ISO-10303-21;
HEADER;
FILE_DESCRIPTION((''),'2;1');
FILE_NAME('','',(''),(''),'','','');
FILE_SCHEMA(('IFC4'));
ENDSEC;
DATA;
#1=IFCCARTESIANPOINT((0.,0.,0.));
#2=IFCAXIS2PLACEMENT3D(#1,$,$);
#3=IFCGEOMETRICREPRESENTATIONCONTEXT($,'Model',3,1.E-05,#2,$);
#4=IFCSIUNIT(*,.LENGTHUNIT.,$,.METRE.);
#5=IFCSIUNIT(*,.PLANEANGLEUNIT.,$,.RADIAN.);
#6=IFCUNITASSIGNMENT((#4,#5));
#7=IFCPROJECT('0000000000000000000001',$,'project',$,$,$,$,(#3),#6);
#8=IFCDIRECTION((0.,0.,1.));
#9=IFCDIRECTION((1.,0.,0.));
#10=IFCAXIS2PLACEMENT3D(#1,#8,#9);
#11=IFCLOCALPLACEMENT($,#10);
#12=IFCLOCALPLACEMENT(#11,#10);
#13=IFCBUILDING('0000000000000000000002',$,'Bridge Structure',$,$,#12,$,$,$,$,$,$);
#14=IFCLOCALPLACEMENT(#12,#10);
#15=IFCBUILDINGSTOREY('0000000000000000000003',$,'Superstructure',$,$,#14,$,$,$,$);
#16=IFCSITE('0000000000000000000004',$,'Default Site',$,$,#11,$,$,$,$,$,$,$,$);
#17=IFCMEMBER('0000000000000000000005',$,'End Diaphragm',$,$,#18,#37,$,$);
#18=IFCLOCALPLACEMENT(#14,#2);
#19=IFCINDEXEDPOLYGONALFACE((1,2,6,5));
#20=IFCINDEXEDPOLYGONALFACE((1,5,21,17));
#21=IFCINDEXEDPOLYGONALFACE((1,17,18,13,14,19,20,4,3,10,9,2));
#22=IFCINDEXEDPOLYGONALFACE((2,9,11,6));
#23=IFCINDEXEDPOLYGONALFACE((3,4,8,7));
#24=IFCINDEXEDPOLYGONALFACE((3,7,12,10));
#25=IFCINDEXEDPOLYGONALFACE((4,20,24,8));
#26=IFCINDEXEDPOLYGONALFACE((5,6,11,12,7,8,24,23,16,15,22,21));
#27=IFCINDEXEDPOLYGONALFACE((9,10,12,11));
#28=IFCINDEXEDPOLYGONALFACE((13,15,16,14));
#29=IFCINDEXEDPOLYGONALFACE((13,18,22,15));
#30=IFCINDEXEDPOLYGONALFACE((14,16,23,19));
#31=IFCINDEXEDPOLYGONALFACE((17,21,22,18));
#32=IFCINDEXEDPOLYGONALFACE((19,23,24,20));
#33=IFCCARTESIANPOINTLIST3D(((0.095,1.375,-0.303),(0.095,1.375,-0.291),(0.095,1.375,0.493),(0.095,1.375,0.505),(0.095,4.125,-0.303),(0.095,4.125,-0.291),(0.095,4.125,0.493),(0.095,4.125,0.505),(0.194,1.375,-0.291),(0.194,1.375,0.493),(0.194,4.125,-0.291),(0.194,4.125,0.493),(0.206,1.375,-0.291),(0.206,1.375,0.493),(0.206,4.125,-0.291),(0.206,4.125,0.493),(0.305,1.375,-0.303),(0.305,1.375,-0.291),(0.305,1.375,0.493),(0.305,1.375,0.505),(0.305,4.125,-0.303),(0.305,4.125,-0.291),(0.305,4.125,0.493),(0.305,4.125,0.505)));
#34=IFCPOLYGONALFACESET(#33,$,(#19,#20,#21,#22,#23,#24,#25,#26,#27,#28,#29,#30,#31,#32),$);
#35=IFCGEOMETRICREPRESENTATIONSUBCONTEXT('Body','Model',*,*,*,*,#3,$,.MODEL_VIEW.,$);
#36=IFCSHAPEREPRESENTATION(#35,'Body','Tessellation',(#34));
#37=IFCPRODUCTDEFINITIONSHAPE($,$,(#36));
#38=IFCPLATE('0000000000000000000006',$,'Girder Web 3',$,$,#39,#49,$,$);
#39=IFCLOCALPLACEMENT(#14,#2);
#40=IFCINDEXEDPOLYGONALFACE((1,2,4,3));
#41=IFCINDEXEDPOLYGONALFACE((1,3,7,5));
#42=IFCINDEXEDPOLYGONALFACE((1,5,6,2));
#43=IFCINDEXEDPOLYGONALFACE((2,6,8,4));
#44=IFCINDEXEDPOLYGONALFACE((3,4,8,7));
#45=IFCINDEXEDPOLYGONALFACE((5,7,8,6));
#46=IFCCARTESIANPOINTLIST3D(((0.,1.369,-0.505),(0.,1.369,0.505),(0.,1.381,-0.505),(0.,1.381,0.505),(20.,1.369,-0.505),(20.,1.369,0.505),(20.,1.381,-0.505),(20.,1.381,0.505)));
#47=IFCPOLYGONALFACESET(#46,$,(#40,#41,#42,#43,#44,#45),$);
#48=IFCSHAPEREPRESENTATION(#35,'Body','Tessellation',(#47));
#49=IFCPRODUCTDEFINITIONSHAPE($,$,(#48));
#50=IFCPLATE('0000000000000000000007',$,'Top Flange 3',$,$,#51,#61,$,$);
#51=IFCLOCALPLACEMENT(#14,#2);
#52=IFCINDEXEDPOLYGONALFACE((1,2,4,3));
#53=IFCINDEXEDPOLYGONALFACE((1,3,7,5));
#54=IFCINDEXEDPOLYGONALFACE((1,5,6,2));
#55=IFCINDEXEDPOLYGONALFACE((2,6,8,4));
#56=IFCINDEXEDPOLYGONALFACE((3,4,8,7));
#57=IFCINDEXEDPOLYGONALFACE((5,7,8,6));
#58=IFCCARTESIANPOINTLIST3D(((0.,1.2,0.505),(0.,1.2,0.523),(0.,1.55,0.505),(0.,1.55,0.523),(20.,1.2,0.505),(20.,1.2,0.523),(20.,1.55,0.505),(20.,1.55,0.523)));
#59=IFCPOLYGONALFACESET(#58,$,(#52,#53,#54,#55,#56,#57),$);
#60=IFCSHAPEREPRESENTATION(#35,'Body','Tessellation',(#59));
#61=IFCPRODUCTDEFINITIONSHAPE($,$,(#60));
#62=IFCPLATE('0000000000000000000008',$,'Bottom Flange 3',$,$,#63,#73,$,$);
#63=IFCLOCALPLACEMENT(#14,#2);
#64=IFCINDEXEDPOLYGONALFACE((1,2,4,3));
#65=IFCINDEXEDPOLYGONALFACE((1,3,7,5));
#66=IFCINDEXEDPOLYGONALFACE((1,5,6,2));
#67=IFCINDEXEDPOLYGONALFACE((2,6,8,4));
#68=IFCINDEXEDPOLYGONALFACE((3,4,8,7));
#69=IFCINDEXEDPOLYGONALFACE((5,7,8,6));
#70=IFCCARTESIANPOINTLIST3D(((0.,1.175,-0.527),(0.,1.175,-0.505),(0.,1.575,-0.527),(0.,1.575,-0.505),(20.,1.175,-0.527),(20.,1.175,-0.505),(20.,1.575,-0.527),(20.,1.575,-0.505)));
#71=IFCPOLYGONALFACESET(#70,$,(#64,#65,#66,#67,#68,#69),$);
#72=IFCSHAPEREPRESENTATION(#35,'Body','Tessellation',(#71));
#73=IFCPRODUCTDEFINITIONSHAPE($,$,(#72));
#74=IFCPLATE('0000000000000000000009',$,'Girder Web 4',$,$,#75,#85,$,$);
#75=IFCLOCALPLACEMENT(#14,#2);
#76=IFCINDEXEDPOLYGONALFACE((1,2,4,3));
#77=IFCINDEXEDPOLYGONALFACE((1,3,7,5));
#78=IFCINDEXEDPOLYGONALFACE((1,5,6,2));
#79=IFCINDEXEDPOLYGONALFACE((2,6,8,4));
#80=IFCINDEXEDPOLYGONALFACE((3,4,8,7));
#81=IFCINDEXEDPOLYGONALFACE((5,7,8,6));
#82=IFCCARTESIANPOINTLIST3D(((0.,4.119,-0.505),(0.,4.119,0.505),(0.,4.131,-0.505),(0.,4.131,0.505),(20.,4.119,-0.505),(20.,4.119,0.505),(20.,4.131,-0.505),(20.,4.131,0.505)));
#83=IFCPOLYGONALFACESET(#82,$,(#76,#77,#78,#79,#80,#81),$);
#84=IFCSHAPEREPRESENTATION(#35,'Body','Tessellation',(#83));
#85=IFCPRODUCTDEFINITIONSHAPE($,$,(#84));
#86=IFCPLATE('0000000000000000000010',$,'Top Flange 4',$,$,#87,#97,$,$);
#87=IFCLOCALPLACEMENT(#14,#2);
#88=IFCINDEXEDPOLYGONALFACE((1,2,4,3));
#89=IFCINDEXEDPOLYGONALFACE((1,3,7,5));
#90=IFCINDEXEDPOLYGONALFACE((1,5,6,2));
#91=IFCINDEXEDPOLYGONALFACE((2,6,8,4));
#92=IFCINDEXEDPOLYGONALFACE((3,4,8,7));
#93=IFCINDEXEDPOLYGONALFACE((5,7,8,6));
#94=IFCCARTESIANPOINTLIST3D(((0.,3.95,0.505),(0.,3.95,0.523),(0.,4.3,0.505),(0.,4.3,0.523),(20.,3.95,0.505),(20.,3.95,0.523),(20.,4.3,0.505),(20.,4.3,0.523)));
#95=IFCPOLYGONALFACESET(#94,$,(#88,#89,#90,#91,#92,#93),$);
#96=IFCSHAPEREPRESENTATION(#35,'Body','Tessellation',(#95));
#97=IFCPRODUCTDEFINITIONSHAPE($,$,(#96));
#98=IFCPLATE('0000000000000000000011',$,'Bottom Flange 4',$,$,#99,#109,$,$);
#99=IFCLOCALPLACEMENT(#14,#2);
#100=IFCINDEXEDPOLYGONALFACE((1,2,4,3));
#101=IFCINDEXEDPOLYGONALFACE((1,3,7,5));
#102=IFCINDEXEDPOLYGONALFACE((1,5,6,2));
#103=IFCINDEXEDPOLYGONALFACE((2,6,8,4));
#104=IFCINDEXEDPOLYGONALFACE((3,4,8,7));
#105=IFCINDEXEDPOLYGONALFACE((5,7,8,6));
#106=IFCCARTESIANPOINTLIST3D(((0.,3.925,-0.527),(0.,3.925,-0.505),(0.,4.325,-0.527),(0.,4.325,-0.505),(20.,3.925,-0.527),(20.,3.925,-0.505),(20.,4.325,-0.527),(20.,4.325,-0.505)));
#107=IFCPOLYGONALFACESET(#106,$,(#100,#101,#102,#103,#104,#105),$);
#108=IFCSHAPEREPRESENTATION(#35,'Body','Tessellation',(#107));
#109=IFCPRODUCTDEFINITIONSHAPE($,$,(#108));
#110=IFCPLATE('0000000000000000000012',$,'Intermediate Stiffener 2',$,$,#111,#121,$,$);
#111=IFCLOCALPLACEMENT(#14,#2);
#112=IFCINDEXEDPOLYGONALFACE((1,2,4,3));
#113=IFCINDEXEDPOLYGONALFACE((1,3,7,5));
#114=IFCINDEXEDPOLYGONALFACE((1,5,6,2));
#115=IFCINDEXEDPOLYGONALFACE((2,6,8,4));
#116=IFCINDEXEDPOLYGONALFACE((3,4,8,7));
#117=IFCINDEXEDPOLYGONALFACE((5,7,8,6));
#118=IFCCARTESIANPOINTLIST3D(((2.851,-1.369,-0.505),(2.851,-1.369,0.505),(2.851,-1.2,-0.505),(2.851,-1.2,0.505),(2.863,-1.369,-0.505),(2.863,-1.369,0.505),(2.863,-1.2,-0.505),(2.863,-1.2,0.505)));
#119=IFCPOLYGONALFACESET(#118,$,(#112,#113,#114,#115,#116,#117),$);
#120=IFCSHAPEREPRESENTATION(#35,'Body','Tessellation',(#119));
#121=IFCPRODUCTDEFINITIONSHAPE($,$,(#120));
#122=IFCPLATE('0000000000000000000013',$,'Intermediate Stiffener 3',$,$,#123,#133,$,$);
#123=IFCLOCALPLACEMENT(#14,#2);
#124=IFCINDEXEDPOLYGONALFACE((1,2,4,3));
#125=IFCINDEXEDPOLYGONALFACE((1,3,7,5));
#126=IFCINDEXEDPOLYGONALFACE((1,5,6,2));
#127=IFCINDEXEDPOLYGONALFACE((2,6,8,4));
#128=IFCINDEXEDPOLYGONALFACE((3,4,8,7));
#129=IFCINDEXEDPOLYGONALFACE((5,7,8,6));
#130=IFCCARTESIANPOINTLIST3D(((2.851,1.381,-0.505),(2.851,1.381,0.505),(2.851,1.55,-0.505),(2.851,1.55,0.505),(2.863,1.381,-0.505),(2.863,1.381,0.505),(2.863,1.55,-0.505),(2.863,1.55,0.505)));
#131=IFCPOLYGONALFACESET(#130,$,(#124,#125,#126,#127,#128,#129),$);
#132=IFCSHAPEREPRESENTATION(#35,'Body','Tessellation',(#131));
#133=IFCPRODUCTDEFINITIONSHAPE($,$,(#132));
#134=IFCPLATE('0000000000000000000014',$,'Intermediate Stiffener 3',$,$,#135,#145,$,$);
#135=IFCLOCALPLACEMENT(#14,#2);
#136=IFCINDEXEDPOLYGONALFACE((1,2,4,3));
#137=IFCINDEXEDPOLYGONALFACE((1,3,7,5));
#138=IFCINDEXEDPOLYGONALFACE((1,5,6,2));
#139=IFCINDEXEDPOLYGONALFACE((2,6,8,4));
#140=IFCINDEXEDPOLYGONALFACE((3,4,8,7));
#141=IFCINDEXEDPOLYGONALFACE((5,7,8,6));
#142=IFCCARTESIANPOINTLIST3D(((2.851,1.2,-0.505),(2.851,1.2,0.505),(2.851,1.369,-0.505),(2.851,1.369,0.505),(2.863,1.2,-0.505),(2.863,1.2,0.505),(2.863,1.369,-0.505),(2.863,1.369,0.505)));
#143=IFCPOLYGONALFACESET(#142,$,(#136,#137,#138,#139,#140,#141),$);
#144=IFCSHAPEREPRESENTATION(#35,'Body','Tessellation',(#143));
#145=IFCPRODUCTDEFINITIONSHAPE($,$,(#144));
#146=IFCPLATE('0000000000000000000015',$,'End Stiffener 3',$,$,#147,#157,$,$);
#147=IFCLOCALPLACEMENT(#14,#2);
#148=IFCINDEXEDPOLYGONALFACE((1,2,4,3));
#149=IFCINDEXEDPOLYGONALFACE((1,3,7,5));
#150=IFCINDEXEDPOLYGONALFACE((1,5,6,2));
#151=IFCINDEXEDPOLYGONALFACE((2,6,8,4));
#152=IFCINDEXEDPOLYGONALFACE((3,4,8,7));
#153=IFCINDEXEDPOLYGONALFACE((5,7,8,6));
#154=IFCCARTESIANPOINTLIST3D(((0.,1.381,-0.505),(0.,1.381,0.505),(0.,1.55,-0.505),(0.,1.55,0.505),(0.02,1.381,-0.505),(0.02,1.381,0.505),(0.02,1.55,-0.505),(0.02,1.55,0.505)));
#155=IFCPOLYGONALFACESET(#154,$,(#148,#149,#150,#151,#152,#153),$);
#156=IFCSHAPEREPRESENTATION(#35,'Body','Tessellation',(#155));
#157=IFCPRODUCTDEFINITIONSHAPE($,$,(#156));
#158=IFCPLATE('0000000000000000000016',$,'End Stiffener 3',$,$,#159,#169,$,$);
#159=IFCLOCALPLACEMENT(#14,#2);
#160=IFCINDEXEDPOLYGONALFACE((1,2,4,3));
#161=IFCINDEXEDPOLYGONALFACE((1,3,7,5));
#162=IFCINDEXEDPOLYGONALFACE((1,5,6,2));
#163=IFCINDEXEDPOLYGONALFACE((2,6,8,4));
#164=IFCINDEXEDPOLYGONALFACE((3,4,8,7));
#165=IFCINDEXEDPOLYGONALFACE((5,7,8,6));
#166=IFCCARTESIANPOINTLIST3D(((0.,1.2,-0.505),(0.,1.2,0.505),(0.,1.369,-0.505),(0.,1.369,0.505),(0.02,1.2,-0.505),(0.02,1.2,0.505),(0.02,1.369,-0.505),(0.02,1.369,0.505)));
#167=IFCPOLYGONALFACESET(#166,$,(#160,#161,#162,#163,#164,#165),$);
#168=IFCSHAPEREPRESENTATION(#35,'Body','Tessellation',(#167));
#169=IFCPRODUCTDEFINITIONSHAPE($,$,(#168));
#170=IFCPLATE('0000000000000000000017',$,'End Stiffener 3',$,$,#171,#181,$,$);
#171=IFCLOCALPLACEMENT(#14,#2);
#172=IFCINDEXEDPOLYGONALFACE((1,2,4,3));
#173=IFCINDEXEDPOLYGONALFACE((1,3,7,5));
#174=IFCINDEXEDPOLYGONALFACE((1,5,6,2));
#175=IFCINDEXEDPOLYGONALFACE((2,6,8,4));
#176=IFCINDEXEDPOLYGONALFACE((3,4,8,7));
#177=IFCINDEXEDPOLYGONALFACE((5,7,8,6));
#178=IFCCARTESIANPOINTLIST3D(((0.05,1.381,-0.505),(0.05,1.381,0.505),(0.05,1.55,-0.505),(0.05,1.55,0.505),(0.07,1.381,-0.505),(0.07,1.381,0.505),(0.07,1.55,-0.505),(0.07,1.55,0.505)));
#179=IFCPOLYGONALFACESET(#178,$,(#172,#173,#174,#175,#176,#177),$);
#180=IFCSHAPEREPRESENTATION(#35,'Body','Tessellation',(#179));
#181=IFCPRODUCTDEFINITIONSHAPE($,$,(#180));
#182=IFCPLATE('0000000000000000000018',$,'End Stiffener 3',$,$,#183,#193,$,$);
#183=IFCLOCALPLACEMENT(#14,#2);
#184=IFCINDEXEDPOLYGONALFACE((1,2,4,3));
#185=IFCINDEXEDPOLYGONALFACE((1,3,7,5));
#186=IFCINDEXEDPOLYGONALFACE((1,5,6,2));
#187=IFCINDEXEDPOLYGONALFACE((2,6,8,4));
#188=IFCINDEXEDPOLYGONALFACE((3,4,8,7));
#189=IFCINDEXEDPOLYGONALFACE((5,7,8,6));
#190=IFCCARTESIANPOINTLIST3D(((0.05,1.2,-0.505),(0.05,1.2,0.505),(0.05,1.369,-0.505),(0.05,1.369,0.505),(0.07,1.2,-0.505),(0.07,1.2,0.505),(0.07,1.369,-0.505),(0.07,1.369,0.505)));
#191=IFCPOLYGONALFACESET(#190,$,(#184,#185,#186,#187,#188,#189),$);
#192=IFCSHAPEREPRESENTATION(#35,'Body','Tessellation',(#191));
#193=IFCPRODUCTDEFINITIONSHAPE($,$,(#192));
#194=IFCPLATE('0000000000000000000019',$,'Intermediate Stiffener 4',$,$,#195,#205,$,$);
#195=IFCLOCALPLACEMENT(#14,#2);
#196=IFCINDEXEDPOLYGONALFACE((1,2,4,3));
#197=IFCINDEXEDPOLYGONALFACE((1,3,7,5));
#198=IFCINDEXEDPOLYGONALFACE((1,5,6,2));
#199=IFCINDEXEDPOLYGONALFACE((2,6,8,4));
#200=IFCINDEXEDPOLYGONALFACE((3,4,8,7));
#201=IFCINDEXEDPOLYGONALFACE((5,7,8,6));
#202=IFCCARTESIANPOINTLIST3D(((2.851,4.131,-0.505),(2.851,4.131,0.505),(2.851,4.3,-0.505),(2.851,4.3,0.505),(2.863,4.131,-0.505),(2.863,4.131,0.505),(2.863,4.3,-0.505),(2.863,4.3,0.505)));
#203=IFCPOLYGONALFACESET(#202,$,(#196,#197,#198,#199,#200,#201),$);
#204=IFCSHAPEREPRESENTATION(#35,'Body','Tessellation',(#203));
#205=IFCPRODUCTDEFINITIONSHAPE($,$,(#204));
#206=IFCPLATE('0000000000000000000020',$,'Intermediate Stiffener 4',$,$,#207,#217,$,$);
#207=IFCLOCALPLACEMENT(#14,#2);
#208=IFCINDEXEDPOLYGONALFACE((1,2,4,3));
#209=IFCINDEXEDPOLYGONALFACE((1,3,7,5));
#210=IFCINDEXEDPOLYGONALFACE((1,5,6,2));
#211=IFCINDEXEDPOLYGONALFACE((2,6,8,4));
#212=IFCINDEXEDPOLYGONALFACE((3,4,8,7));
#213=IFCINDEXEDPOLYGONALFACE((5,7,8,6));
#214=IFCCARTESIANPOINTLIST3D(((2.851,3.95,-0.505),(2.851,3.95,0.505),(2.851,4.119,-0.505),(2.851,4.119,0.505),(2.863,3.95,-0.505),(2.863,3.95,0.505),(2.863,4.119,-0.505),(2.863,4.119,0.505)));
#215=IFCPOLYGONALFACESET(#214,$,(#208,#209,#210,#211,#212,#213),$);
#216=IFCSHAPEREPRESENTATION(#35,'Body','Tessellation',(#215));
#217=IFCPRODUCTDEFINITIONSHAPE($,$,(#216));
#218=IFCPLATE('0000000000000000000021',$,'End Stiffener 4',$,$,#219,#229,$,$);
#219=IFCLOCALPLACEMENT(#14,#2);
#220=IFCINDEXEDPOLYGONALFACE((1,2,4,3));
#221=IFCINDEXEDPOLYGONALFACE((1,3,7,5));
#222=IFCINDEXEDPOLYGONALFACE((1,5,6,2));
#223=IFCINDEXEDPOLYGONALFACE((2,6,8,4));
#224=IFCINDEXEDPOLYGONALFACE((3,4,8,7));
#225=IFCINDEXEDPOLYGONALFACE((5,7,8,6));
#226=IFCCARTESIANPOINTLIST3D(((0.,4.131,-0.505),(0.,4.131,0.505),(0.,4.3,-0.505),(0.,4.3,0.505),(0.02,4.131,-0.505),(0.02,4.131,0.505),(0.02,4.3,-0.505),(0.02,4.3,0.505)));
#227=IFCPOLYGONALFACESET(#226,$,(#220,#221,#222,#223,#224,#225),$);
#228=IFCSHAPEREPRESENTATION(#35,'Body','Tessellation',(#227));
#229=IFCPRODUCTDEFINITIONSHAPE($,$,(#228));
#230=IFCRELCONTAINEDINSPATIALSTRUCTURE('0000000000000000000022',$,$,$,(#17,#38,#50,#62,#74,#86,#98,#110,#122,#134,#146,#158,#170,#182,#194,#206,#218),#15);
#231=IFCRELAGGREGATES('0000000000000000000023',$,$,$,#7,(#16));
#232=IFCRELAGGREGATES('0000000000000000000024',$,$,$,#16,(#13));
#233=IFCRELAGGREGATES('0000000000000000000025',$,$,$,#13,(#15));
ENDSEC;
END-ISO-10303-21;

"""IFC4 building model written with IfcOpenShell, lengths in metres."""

from ifc_helpers import new_model, si_unit, frame, origin, origin_with_axes, origin_2d_with_axis, place, context, subcontext, project, spatial, rectangle, i_section, extrude, element, save


model = new_model("IFC4")

# Units and contexts
model_context = context("Model", 3, precision=1e-05, world=origin())
body_context = subcontext(model_context, "Body", "Model", "MODEL_VIEW")
ifc_project = project(units=[si_unit("LENGTHUNIT", "METRE"), si_unit("PLANEANGLEUNIT", "RADIAN")], contexts=[model_context])

# Site, building, storey
site_placement = place(None, origin_with_axes())
site = spatial("IfcSite", under=ifc_project, at=site_placement, Name="Default Site")
building_placement = place(site_placement, origin_with_axes())
building = spatial("IfcBuilding", under=site, at=building_placement, Name="Bridge Structure")
storey_placement = place(building_placement, origin_with_axes())
storey = spatial("IfcBuildingStorey", under=building, at=storey_placement, Name="Superstructure")

# Member
member_placement = place(storey_placement, frame((0.2, 1.375, 0.101), z_axis=(0.0, 1.0, 0.0), x_axis=(-1.0, 0.0, 0.0)))
element("IfcMember", 1, at=member_placement, inside=storey, Name="End Diaphragm", context=body_context, shape_type="SweptSolid", body=[
    extrude(i_section(OverallWidth=0.21, OverallDepth=0.808, WebThickness=0.012, FlangeThickness=0.012, at=origin_2d_with_axis()), origin_with_axes(), (0.0, 0.0, 1.0), 2.75),
])

# Plates
plate_1_placement = place(storey_placement, frame((0.0, 1.375, 0.0), z_axis=(1.0, 0.0, 0.0), x_axis=(0.0, 1.0, 0.0)))
element("IfcPlate", 2, at=plate_1_placement, inside=storey, Name="Girder Web 3", context=body_context, shape_type="SweptSolid", body=[
    extrude(rectangle(XDim=0.012, YDim=1.01, at=origin_2d_with_axis()), origin_with_axes(), (0.0, 0.0, 1.0), 20.0),
])
plate_2_placement = place(storey_placement, frame((0.0, 1.375, 0.514), z_axis=(1.0, 0.0, 0.0), x_axis=(0.0, 1.0, 0.0)))
element("IfcPlate", 3, at=plate_2_placement, inside=storey, Name="Top Flange 3", context=body_context, shape_type="SweptSolid", body=[
    extrude(rectangle(XDim=0.35, YDim=0.018, at=origin_2d_with_axis()), origin_with_axes(), (0.0, 0.0, 1.0), 20.0),
])
plate_3_placement = place(storey_placement, frame((0.0, 1.375, -0.516), z_axis=(1.0, 0.0, 0.0), x_axis=(0.0, 1.0, 0.0)))
element("IfcPlate", 4, at=plate_3_placement, inside=storey, Name="Bottom Flange 3", context=body_context, shape_type="SweptSolid", body=[
    extrude(rectangle(XDim=0.4, YDim=0.022, at=origin_2d_with_axis()), origin_with_axes(), (0.0, 0.0, 1.0), 20.0),
])
plate_4_placement = place(storey_placement, frame((0.0, 4.125, 0.0), z_axis=(1.0, 0.0, 0.0), x_axis=(0.0, 1.0, 0.0)))
element("IfcPlate", 5, at=plate_4_placement, inside=storey, Name="Girder Web 4", context=body_context, shape_type="SweptSolid", body=[
    extrude(rectangle(XDim=0.012, YDim=1.01, at=origin_2d_with_axis()), origin_with_axes(), (0.0, 0.0, 1.0), 20.0),
])
plate_5_placement = place(storey_placement, frame((0.0, 4.125, 0.514), z_axis=(1.0, 0.0, 0.0), x_axis=(0.0, 1.0, 0.0)))
element("IfcPlate", 6, at=plate_5_placement, inside=storey, Name="Top Flange 4", context=body_context, shape_type="SweptSolid", body=[
    extrude(rectangle(XDim=0.35, YDim=0.018, at=origin_2d_with_axis()), origin_with_axes(), (0.0, 0.0, 1.0), 20.0),
])
plate_6_placement = place(storey_placement, frame((0.0, 4.125, -0.516), z_axis=(1.0, 0.0, 0.0), x_axis=(0.0, 1.0, 0.0)))
element("IfcPlate", 7, at=plate_6_placement, inside=storey, Name="Bottom Flange 4", context=body_context, shape_type="SweptSolid", body=[
    extrude(rectangle(XDim=0.4, YDim=0.022, at=origin_2d_with_axis()), origin_with_axes(), (0.0, 0.0, 1.0), 20.0),
])
for number, where, z_axis, x_axis, name in (
    (8, (2.857, -1.2845, -0.505), (0.0, 0.0, 1.0), (1.0, 0.0, 0.0), "Intermediate Stiffener 2"),
    (9, (2.857, 1.4655, -0.505), (0.0, 0.0, 1.0), (1.0, 0.0, 0.0), "Intermediate Stiffener 3"),
    (10, (2.857, 1.2845, -0.505), (0.0, 0.0, 1.0), (1.0, 0.0, 0.0), "Intermediate Stiffener 3"),
):
    element("IfcPlate", number, at=place(storey_placement, frame(where, z_axis=z_axis, x_axis=x_axis)), inside=storey, Name=name, context=body_context, shape_type="SweptSolid", body=[
        extrude(rectangle(XDim=0.012, YDim=0.169, at=origin_2d_with_axis()), origin_with_axes(), (0.0, 0.0, 1.0), 1.01),
    ])
for number, where, z_axis, x_axis, name in (
    (11, (0.01, 1.4655, -0.505), (0.0, 0.0, 1.0), (1.0, 0.0, 0.0), "End Stiffener 3"),
    (12, (0.01, 1.2845, -0.505), (0.0, 0.0, 1.0), (1.0, 0.0, 0.0), "End Stiffener 3"),
    (13, (0.06, 1.4655, -0.505), (0.0, 0.0, 1.0), (1.0, 0.0, 0.0), "End Stiffener 3"),
    (14, (0.06, 1.2845, -0.505), (0.0, 0.0, 1.0), (1.0, 0.0, 0.0), "End Stiffener 3"),
):
    element("IfcPlate", number, at=place(storey_placement, frame(where, z_axis=z_axis, x_axis=x_axis)), inside=storey, Name=name, context=body_context, shape_type="SweptSolid", body=[
        extrude(rectangle(XDim=0.02, YDim=0.169, at=origin_2d_with_axis()), origin_with_axes(), (0.0, 0.0, 1.0), 1.01),
    ])
for number, where, z_axis, x_axis, name in (
    (15, (2.857, 4.2155, -0.505), (0.0, 0.0, 1.0), (1.0, 0.0, 0.0), "Intermediate Stiffener 4"),
    (16, (2.857, 4.0345, -0.505), (0.0, 0.0, 1.0), (1.0, 0.0, 0.0), "Intermediate Stiffener 4"),
):
    element("IfcPlate", number, at=place(storey_placement, frame(where, z_axis=z_axis, x_axis=x_axis)), inside=storey, Name=name, context=body_context, shape_type="SweptSolid", body=[
        extrude(rectangle(XDim=0.012, YDim=0.169, at=origin_2d_with_axis()), origin_with_axes(), (0.0, 0.0, 1.0), 1.01),
    ])
for number, where, z_axis, x_axis, name in (
    (17, (0.01, 4.2155, -0.505), (0.0, 0.0, 1.0), (1.0, 0.0, 0.0), "End Stiffener 4"),
):
    element("IfcPlate", number, at=place(storey_placement, frame(where, z_axis=z_axis, x_axis=x_axis)), inside=storey, Name=name, context=body_context, shape_type="SweptSolid", body=[
        extrude(rectangle(XDim=0.02, YDim=0.169, at=origin_2d_with_axis()), origin_with_axes(), (0.0, 0.0, 1.0), 1.01),
    ])

save(model, "model.ifc")
